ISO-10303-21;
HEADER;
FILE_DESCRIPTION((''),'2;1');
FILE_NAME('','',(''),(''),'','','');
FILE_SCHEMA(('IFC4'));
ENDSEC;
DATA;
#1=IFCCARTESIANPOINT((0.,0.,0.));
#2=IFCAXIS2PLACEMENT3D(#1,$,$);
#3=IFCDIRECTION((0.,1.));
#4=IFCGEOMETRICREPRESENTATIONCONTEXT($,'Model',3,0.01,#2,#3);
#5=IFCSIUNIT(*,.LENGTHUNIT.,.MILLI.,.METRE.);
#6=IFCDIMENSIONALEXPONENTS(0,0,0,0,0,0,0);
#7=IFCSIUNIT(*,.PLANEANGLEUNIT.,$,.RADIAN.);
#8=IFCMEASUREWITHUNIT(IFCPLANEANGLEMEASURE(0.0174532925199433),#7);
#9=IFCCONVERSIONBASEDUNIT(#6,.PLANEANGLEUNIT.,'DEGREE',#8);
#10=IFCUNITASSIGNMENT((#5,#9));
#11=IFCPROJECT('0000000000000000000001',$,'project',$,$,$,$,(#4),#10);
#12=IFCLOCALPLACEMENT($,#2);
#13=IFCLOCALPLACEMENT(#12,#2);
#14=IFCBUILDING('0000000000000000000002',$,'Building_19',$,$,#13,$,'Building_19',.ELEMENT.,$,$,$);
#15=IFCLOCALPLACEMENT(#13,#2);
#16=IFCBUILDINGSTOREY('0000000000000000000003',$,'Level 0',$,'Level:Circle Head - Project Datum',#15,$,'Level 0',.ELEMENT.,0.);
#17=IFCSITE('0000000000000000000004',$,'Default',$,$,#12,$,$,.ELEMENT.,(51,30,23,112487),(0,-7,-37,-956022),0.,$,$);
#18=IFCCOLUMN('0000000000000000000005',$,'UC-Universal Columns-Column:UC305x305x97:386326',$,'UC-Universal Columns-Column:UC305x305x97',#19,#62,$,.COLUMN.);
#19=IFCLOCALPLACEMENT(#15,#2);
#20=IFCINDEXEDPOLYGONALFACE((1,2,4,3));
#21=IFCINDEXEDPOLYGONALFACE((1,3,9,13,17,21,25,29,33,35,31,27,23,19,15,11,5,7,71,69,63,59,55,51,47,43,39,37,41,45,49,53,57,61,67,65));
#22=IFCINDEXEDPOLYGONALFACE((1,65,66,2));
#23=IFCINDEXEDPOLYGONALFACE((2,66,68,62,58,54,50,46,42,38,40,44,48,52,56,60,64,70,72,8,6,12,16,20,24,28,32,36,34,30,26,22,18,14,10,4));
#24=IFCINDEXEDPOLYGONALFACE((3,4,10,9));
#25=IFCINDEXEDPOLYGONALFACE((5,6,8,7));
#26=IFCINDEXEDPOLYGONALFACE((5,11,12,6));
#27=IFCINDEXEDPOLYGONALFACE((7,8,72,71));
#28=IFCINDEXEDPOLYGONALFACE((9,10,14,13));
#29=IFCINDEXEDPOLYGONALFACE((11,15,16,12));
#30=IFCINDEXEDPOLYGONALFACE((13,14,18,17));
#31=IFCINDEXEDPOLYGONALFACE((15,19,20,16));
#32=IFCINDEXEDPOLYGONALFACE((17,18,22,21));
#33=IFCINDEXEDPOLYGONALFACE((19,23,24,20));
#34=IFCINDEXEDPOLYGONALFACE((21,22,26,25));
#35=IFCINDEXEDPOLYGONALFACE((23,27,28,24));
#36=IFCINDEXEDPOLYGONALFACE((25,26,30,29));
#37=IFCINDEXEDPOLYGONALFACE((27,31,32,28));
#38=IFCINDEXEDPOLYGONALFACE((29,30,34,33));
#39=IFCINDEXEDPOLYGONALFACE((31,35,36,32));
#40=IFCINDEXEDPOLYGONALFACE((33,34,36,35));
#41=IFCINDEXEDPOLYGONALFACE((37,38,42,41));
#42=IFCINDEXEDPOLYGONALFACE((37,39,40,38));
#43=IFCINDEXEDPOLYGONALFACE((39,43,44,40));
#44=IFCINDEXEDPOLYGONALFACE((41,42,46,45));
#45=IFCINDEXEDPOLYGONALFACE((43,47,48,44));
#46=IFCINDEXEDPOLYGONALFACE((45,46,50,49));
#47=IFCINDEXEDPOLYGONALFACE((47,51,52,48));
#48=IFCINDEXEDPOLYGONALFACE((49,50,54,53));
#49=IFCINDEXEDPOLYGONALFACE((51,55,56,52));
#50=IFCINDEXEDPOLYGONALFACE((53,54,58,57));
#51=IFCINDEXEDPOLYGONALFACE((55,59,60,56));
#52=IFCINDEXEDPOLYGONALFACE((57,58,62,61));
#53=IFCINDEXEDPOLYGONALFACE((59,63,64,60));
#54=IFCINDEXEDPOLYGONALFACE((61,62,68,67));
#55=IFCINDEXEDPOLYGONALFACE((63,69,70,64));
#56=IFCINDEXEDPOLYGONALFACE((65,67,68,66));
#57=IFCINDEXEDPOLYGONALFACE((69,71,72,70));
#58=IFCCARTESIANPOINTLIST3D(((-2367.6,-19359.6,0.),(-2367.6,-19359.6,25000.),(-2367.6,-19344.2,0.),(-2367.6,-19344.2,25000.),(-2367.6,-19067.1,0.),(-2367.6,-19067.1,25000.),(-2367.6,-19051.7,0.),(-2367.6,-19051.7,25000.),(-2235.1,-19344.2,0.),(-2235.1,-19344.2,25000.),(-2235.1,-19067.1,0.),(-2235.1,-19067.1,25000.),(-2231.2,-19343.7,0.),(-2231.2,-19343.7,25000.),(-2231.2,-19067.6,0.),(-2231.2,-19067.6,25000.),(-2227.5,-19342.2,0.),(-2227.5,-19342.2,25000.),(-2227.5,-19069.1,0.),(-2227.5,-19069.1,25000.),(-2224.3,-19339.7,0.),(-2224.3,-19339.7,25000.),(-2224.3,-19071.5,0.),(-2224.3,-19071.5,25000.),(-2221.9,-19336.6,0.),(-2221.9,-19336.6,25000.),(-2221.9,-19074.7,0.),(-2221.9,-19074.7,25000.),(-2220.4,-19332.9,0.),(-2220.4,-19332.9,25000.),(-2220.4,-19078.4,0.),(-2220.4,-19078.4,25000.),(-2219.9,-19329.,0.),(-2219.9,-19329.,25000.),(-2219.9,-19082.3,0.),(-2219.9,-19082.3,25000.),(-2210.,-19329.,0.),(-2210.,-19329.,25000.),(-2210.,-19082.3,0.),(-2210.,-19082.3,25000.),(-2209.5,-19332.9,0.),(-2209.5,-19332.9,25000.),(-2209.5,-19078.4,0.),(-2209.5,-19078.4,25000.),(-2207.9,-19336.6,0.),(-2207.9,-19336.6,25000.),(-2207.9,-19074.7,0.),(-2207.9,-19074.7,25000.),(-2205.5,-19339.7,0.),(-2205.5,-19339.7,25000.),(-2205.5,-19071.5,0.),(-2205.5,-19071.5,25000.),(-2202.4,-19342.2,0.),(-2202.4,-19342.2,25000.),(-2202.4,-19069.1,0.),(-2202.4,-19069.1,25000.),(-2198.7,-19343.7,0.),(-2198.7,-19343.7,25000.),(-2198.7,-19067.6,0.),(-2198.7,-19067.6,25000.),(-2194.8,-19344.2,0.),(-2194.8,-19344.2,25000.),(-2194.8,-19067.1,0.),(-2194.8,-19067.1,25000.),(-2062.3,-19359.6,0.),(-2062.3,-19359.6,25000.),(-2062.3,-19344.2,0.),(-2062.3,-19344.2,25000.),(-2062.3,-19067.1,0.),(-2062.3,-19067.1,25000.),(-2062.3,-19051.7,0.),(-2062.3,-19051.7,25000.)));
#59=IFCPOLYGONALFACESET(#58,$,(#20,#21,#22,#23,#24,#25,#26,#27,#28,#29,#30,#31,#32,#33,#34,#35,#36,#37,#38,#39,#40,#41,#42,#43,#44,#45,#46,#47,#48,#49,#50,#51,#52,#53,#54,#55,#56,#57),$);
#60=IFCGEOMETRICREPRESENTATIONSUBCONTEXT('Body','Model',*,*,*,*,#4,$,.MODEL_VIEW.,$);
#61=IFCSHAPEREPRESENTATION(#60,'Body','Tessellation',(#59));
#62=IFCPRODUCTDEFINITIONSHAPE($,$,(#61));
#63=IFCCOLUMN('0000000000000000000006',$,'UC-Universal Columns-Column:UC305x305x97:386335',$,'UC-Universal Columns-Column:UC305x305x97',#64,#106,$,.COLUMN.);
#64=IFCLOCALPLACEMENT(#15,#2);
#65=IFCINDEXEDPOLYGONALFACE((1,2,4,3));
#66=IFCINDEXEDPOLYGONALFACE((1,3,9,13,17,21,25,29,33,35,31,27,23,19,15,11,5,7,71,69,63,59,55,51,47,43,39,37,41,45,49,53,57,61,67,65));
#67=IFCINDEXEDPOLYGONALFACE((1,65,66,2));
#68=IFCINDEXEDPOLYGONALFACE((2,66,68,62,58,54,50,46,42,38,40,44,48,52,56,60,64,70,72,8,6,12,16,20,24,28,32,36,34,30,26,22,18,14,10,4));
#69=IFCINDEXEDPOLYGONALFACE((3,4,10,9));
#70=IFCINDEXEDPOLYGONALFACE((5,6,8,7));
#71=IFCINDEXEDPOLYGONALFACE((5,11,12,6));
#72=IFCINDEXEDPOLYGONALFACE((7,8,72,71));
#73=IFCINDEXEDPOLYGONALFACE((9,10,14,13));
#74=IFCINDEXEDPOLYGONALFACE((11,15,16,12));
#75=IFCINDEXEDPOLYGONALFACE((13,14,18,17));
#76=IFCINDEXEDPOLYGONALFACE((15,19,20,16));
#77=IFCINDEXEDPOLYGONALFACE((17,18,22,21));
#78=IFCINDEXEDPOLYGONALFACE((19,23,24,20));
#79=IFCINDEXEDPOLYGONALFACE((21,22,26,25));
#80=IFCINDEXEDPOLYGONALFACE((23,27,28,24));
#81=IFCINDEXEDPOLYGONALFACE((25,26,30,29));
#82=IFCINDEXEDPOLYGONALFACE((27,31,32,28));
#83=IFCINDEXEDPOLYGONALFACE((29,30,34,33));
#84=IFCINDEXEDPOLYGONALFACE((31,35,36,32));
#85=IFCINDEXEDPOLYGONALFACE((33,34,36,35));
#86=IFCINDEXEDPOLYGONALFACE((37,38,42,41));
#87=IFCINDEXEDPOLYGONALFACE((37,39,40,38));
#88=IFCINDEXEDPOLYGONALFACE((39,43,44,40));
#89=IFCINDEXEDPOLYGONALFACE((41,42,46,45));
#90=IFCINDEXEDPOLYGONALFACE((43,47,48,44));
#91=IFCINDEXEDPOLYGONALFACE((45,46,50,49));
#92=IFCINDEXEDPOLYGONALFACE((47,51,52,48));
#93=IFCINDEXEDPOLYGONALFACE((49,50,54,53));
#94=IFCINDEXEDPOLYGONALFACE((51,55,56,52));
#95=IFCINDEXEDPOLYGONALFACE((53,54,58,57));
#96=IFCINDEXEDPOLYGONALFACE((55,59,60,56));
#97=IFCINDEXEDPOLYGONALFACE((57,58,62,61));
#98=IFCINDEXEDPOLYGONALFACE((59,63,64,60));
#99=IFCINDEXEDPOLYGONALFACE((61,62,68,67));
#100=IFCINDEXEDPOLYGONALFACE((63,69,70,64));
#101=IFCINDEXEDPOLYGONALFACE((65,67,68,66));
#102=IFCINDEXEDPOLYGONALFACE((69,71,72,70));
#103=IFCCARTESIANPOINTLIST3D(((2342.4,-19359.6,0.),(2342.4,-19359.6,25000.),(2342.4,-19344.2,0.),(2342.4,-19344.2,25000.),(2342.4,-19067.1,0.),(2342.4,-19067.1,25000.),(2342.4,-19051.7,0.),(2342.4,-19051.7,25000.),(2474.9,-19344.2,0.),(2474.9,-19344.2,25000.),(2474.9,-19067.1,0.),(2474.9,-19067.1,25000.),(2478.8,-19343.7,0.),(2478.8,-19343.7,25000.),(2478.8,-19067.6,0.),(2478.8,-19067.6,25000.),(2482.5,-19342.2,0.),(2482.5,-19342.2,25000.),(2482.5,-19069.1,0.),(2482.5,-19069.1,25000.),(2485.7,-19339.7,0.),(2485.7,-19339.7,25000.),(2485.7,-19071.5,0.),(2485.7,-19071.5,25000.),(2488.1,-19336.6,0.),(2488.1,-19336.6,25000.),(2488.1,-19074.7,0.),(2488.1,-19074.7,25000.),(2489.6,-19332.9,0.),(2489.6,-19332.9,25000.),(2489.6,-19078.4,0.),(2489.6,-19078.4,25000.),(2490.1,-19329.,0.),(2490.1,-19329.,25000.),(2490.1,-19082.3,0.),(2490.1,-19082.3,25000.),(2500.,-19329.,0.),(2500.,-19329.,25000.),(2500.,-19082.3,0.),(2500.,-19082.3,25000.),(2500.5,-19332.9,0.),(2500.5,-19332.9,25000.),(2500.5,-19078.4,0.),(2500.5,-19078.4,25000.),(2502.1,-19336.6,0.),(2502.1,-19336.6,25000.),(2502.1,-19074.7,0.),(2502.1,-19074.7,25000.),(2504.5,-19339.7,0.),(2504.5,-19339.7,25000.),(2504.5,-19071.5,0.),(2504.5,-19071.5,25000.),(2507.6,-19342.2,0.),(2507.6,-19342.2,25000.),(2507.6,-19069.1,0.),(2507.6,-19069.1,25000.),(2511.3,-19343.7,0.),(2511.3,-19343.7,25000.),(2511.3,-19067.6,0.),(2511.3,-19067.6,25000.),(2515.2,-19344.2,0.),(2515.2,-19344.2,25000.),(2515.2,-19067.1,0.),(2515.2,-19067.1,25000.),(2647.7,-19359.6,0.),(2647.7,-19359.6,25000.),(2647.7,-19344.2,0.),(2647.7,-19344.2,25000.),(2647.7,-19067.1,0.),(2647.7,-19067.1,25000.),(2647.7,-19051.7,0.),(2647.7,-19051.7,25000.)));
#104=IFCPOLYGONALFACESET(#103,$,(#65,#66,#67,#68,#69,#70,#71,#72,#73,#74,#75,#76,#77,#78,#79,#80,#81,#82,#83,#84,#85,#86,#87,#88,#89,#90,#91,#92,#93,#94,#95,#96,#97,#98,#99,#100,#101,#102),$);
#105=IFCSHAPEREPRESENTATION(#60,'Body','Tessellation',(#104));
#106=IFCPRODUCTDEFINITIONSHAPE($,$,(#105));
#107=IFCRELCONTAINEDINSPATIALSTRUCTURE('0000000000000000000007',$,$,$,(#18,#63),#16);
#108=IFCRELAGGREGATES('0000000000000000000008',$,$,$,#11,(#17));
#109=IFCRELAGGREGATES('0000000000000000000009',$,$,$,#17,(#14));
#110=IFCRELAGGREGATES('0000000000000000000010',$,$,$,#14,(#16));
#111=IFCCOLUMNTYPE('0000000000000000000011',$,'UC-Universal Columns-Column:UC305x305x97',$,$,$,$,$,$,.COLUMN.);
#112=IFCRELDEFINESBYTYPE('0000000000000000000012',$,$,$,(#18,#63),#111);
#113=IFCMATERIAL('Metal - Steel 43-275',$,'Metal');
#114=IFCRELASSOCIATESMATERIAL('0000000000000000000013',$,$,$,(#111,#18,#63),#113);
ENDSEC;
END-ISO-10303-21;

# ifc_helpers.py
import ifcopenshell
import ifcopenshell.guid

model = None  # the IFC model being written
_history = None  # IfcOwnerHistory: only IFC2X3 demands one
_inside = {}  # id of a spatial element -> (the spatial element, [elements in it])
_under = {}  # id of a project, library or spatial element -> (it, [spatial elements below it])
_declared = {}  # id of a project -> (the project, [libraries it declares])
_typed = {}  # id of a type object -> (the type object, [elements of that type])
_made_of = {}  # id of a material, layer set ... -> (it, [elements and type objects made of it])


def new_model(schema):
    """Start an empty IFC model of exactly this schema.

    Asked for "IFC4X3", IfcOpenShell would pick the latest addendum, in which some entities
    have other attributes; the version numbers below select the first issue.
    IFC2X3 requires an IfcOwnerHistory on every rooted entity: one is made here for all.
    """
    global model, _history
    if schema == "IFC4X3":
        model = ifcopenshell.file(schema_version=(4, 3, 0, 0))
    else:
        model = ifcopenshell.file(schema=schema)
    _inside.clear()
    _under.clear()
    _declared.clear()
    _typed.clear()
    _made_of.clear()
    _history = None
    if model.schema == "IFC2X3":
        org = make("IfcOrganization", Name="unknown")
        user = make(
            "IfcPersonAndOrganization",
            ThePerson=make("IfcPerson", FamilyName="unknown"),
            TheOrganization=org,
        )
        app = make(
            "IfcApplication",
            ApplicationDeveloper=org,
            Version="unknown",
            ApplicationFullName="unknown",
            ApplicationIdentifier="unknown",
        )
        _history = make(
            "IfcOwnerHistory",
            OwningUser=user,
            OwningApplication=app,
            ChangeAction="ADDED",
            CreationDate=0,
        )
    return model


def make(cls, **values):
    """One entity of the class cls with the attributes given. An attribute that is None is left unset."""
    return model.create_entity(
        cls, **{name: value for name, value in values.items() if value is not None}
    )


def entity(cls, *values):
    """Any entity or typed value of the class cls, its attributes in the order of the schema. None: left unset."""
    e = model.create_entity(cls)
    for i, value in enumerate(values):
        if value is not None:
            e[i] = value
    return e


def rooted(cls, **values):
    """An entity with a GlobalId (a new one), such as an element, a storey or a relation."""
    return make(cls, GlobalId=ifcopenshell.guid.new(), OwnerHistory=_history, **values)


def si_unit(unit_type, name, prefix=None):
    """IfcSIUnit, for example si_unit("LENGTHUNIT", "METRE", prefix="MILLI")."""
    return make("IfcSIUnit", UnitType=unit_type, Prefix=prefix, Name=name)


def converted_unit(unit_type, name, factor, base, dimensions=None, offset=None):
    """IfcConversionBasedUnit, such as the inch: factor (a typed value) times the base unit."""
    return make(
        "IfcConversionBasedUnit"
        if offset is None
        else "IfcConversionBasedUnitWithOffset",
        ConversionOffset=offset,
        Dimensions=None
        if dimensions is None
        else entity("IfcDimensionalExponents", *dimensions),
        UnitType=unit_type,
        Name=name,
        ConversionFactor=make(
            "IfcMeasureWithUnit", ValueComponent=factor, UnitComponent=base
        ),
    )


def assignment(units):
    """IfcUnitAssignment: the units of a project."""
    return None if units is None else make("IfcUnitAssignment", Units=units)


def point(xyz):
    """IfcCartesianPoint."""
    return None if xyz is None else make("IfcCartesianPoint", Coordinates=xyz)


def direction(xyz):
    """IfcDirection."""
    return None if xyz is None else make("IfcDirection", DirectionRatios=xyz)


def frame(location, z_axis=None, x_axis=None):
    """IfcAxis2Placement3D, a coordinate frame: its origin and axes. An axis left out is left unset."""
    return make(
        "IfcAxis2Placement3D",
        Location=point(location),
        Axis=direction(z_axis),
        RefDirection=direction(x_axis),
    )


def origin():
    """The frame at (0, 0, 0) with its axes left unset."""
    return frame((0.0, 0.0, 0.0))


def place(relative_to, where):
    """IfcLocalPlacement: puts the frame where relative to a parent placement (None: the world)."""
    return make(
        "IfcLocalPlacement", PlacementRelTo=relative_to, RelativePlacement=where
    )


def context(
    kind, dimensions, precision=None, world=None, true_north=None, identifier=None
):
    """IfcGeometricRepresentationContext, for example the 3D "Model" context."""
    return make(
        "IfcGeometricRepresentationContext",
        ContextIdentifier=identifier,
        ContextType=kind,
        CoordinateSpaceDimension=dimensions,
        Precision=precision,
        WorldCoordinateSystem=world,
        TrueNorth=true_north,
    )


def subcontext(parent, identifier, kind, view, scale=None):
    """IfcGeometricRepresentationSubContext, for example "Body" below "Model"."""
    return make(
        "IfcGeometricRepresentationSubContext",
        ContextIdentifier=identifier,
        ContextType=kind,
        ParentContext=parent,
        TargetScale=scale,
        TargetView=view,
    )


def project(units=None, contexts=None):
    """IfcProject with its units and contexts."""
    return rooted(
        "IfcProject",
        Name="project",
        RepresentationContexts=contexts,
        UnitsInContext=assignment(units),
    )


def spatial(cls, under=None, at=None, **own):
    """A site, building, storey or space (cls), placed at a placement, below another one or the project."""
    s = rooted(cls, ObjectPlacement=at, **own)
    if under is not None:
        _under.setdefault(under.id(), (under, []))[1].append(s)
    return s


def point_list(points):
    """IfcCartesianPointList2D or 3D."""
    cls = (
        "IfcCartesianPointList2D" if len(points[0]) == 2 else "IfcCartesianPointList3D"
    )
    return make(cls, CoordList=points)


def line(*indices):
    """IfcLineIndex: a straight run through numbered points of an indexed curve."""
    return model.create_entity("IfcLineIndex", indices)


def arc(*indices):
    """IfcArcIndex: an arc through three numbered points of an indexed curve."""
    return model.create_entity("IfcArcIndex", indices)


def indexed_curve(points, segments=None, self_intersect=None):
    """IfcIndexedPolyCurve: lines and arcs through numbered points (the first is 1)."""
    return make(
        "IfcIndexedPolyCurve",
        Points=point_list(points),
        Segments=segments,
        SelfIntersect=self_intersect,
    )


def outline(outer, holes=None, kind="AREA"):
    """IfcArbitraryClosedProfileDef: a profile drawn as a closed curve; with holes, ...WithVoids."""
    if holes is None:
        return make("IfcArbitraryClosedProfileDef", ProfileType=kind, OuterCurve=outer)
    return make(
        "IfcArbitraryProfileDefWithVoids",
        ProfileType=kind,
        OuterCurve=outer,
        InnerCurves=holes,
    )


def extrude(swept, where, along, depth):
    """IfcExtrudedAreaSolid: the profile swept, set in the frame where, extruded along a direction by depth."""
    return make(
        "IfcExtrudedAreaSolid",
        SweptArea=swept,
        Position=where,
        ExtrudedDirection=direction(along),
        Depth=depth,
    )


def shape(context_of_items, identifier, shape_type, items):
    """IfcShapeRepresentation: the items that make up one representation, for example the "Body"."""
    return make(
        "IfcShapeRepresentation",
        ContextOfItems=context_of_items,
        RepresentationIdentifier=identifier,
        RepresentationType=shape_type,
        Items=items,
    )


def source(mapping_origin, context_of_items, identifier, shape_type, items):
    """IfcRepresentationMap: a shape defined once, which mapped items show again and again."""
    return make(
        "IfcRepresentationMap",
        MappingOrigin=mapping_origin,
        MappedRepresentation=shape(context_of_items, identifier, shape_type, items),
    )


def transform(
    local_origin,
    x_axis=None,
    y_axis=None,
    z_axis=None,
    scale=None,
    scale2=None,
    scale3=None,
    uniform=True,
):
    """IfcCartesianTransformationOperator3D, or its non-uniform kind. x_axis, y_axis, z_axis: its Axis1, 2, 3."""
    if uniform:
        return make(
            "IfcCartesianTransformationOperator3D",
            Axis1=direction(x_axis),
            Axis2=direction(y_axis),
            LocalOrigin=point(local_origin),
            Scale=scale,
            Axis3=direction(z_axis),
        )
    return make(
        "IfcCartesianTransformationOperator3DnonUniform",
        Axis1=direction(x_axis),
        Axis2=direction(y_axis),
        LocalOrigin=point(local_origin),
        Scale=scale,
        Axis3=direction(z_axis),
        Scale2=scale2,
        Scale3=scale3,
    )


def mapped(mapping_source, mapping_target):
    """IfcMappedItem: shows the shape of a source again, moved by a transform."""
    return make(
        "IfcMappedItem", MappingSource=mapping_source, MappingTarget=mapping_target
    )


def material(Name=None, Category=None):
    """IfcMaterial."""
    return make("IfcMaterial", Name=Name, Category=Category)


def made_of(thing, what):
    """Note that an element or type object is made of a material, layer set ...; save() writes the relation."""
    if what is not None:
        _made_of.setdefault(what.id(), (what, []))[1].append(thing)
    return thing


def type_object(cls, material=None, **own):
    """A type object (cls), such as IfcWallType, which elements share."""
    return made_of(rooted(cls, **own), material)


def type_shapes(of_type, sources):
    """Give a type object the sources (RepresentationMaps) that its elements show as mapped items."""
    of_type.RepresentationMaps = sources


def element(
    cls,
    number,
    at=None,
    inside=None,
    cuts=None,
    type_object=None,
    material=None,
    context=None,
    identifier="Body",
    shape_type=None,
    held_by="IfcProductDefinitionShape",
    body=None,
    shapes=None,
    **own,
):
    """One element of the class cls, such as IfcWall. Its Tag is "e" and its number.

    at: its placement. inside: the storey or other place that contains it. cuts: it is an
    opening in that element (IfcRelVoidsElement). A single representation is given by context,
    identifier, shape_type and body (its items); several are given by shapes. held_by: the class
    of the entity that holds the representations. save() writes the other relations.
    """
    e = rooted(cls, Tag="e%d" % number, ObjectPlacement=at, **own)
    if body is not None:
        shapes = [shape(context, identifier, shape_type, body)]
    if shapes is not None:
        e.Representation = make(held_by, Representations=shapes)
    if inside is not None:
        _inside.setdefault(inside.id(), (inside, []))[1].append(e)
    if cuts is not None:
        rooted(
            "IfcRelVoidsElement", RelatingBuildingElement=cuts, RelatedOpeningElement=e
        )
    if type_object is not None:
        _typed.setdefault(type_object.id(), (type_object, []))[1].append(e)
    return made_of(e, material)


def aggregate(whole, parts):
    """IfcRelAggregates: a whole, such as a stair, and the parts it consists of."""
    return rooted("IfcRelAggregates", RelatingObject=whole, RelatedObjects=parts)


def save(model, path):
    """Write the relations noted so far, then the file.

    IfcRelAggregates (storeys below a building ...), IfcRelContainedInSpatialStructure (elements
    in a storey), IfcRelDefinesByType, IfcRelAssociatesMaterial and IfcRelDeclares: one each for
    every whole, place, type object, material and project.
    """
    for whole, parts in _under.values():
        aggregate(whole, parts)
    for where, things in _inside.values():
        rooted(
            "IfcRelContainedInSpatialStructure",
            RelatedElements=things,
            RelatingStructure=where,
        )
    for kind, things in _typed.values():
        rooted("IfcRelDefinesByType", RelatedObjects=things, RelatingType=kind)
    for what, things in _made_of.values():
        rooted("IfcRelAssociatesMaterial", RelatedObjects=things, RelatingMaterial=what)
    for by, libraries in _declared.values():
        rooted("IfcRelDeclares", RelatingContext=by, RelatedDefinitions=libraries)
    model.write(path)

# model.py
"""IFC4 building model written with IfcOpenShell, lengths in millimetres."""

from ifc_helpers import new_model, entity, si_unit, converted_unit, direction, frame, origin, place, context, subcontext, project, spatial, line, arc, indexed_curve, outline, extrude, source, transform, mapped, material, type_object, type_shapes, element, save


model = new_model("IFC4")

# Units and contexts
model_context = context("Model", 3, precision=0.01, world=origin(), true_north=direction((0.0, 1.0)))
body_context = subcontext(model_context, "Body", "Model", "MODEL_VIEW")
ifc_project = project(units=[si_unit("LENGTHUNIT", "METRE", prefix="MILLI"), converted_unit("PLANEANGLEUNIT", "DEGREE", entity("IfcPlaneAngleMeasure", 0.0174532925199433), si_unit("PLANEANGLEUNIT", "RADIAN"), dimensions=[0, 0, 0, 0, 0, 0, 0])], contexts=[model_context])

# Site, building, storey
site_placement = place(None, origin())
site = spatial("IfcSite", under=ifc_project, at=site_placement, Name="Default", CompositionType="ELEMENT", RefLatitude=(51, 30, 23, 112487), RefLongitude=(0, -7, -37, -956022), RefElevation=0.0)
building_placement = place(site_placement, origin())
building = spatial("IfcBuilding", under=site, at=building_placement, Name="Building_19", LongName="Building_19", CompositionType="ELEMENT")
storey_placement = place(building_placement, origin())
storey = spatial("IfcBuildingStorey", under=building, at=storey_placement, Name="Level 0", ObjectType="Level:Circle Head - Project Datum", LongName="Level 0", CompositionType="ELEMENT", Elevation=0.0)

# Columns
ifc_material_1 = material(Name="Metal - Steel 43-275", Category="Metal")
column_type = type_object("IfcColumnType", Name="UC-Universal Columns-Column:UC305x305x97", PredefinedType="COLUMN", material=ifc_material_1)
shared_shape_1 = source(origin(), body_context, "Body", "SweptSolid", [
    extrude(outline(indexed_curve([(-152.7, -153.9), (152.7, -153.9), (152.7, -138.6), (20.2, -138.6), (9.4, -134.1), (4.9, -123.3), (4.9, 123.3), (9.4, 134.1), (20.1, 138.6), (152.7, 138.6), (152.7, 153.9), (-152.7, 153.9), (-152.7, 138.6), (-20.2, 138.6), (-9.4, 134.1), (-5.0, 123.3), (-5.0, -123.3), (-9.4, -134.1), (-20.2, -138.6), (-152.7, -138.6)], segments=[line(1, 2, 3, 4), arc(4, 5, 6), line(6, 7), arc(7, 8, 9), line(9, 10, 11, 12, 13, 14), arc(14, 15, 16), line(16, 17), arc(17, 18, 19), line(19, 20, 1)], self_intersect=False)), frame((0.0, 0.0, 0.0), z_axis=(0.0, 0.0, 1.0), x_axis=(-1.0, 0.0, 0.0)), (0.0, 0.0, 1.0), 25000.0),
])
type_shapes(column_type, [shared_shape_1])
for number, where, name in (
    (1, (-2214.9, -19205.6, 0.0), "UC-Universal Columns-Column:UC305x305x97:386326"),
    (2, (2495.1, -19205.6, 0.0), "UC-Universal Columns-Column:UC305x305x97:386335"),
):
    element("IfcColumn", number, at=place(storey_placement, frame(where)), inside=storey, type_object=column_type, material=ifc_material_1, Name=name, ObjectType="UC-Universal Columns-Column:UC305x305x97", PredefinedType="COLUMN", context=body_context, shape_type="MappedRepresentation", body=[
        mapped(shared_shape_1, transform((0.0, 0.0, 0.0), scale=1.0)),
    ])

save(model, "model.ifc")
